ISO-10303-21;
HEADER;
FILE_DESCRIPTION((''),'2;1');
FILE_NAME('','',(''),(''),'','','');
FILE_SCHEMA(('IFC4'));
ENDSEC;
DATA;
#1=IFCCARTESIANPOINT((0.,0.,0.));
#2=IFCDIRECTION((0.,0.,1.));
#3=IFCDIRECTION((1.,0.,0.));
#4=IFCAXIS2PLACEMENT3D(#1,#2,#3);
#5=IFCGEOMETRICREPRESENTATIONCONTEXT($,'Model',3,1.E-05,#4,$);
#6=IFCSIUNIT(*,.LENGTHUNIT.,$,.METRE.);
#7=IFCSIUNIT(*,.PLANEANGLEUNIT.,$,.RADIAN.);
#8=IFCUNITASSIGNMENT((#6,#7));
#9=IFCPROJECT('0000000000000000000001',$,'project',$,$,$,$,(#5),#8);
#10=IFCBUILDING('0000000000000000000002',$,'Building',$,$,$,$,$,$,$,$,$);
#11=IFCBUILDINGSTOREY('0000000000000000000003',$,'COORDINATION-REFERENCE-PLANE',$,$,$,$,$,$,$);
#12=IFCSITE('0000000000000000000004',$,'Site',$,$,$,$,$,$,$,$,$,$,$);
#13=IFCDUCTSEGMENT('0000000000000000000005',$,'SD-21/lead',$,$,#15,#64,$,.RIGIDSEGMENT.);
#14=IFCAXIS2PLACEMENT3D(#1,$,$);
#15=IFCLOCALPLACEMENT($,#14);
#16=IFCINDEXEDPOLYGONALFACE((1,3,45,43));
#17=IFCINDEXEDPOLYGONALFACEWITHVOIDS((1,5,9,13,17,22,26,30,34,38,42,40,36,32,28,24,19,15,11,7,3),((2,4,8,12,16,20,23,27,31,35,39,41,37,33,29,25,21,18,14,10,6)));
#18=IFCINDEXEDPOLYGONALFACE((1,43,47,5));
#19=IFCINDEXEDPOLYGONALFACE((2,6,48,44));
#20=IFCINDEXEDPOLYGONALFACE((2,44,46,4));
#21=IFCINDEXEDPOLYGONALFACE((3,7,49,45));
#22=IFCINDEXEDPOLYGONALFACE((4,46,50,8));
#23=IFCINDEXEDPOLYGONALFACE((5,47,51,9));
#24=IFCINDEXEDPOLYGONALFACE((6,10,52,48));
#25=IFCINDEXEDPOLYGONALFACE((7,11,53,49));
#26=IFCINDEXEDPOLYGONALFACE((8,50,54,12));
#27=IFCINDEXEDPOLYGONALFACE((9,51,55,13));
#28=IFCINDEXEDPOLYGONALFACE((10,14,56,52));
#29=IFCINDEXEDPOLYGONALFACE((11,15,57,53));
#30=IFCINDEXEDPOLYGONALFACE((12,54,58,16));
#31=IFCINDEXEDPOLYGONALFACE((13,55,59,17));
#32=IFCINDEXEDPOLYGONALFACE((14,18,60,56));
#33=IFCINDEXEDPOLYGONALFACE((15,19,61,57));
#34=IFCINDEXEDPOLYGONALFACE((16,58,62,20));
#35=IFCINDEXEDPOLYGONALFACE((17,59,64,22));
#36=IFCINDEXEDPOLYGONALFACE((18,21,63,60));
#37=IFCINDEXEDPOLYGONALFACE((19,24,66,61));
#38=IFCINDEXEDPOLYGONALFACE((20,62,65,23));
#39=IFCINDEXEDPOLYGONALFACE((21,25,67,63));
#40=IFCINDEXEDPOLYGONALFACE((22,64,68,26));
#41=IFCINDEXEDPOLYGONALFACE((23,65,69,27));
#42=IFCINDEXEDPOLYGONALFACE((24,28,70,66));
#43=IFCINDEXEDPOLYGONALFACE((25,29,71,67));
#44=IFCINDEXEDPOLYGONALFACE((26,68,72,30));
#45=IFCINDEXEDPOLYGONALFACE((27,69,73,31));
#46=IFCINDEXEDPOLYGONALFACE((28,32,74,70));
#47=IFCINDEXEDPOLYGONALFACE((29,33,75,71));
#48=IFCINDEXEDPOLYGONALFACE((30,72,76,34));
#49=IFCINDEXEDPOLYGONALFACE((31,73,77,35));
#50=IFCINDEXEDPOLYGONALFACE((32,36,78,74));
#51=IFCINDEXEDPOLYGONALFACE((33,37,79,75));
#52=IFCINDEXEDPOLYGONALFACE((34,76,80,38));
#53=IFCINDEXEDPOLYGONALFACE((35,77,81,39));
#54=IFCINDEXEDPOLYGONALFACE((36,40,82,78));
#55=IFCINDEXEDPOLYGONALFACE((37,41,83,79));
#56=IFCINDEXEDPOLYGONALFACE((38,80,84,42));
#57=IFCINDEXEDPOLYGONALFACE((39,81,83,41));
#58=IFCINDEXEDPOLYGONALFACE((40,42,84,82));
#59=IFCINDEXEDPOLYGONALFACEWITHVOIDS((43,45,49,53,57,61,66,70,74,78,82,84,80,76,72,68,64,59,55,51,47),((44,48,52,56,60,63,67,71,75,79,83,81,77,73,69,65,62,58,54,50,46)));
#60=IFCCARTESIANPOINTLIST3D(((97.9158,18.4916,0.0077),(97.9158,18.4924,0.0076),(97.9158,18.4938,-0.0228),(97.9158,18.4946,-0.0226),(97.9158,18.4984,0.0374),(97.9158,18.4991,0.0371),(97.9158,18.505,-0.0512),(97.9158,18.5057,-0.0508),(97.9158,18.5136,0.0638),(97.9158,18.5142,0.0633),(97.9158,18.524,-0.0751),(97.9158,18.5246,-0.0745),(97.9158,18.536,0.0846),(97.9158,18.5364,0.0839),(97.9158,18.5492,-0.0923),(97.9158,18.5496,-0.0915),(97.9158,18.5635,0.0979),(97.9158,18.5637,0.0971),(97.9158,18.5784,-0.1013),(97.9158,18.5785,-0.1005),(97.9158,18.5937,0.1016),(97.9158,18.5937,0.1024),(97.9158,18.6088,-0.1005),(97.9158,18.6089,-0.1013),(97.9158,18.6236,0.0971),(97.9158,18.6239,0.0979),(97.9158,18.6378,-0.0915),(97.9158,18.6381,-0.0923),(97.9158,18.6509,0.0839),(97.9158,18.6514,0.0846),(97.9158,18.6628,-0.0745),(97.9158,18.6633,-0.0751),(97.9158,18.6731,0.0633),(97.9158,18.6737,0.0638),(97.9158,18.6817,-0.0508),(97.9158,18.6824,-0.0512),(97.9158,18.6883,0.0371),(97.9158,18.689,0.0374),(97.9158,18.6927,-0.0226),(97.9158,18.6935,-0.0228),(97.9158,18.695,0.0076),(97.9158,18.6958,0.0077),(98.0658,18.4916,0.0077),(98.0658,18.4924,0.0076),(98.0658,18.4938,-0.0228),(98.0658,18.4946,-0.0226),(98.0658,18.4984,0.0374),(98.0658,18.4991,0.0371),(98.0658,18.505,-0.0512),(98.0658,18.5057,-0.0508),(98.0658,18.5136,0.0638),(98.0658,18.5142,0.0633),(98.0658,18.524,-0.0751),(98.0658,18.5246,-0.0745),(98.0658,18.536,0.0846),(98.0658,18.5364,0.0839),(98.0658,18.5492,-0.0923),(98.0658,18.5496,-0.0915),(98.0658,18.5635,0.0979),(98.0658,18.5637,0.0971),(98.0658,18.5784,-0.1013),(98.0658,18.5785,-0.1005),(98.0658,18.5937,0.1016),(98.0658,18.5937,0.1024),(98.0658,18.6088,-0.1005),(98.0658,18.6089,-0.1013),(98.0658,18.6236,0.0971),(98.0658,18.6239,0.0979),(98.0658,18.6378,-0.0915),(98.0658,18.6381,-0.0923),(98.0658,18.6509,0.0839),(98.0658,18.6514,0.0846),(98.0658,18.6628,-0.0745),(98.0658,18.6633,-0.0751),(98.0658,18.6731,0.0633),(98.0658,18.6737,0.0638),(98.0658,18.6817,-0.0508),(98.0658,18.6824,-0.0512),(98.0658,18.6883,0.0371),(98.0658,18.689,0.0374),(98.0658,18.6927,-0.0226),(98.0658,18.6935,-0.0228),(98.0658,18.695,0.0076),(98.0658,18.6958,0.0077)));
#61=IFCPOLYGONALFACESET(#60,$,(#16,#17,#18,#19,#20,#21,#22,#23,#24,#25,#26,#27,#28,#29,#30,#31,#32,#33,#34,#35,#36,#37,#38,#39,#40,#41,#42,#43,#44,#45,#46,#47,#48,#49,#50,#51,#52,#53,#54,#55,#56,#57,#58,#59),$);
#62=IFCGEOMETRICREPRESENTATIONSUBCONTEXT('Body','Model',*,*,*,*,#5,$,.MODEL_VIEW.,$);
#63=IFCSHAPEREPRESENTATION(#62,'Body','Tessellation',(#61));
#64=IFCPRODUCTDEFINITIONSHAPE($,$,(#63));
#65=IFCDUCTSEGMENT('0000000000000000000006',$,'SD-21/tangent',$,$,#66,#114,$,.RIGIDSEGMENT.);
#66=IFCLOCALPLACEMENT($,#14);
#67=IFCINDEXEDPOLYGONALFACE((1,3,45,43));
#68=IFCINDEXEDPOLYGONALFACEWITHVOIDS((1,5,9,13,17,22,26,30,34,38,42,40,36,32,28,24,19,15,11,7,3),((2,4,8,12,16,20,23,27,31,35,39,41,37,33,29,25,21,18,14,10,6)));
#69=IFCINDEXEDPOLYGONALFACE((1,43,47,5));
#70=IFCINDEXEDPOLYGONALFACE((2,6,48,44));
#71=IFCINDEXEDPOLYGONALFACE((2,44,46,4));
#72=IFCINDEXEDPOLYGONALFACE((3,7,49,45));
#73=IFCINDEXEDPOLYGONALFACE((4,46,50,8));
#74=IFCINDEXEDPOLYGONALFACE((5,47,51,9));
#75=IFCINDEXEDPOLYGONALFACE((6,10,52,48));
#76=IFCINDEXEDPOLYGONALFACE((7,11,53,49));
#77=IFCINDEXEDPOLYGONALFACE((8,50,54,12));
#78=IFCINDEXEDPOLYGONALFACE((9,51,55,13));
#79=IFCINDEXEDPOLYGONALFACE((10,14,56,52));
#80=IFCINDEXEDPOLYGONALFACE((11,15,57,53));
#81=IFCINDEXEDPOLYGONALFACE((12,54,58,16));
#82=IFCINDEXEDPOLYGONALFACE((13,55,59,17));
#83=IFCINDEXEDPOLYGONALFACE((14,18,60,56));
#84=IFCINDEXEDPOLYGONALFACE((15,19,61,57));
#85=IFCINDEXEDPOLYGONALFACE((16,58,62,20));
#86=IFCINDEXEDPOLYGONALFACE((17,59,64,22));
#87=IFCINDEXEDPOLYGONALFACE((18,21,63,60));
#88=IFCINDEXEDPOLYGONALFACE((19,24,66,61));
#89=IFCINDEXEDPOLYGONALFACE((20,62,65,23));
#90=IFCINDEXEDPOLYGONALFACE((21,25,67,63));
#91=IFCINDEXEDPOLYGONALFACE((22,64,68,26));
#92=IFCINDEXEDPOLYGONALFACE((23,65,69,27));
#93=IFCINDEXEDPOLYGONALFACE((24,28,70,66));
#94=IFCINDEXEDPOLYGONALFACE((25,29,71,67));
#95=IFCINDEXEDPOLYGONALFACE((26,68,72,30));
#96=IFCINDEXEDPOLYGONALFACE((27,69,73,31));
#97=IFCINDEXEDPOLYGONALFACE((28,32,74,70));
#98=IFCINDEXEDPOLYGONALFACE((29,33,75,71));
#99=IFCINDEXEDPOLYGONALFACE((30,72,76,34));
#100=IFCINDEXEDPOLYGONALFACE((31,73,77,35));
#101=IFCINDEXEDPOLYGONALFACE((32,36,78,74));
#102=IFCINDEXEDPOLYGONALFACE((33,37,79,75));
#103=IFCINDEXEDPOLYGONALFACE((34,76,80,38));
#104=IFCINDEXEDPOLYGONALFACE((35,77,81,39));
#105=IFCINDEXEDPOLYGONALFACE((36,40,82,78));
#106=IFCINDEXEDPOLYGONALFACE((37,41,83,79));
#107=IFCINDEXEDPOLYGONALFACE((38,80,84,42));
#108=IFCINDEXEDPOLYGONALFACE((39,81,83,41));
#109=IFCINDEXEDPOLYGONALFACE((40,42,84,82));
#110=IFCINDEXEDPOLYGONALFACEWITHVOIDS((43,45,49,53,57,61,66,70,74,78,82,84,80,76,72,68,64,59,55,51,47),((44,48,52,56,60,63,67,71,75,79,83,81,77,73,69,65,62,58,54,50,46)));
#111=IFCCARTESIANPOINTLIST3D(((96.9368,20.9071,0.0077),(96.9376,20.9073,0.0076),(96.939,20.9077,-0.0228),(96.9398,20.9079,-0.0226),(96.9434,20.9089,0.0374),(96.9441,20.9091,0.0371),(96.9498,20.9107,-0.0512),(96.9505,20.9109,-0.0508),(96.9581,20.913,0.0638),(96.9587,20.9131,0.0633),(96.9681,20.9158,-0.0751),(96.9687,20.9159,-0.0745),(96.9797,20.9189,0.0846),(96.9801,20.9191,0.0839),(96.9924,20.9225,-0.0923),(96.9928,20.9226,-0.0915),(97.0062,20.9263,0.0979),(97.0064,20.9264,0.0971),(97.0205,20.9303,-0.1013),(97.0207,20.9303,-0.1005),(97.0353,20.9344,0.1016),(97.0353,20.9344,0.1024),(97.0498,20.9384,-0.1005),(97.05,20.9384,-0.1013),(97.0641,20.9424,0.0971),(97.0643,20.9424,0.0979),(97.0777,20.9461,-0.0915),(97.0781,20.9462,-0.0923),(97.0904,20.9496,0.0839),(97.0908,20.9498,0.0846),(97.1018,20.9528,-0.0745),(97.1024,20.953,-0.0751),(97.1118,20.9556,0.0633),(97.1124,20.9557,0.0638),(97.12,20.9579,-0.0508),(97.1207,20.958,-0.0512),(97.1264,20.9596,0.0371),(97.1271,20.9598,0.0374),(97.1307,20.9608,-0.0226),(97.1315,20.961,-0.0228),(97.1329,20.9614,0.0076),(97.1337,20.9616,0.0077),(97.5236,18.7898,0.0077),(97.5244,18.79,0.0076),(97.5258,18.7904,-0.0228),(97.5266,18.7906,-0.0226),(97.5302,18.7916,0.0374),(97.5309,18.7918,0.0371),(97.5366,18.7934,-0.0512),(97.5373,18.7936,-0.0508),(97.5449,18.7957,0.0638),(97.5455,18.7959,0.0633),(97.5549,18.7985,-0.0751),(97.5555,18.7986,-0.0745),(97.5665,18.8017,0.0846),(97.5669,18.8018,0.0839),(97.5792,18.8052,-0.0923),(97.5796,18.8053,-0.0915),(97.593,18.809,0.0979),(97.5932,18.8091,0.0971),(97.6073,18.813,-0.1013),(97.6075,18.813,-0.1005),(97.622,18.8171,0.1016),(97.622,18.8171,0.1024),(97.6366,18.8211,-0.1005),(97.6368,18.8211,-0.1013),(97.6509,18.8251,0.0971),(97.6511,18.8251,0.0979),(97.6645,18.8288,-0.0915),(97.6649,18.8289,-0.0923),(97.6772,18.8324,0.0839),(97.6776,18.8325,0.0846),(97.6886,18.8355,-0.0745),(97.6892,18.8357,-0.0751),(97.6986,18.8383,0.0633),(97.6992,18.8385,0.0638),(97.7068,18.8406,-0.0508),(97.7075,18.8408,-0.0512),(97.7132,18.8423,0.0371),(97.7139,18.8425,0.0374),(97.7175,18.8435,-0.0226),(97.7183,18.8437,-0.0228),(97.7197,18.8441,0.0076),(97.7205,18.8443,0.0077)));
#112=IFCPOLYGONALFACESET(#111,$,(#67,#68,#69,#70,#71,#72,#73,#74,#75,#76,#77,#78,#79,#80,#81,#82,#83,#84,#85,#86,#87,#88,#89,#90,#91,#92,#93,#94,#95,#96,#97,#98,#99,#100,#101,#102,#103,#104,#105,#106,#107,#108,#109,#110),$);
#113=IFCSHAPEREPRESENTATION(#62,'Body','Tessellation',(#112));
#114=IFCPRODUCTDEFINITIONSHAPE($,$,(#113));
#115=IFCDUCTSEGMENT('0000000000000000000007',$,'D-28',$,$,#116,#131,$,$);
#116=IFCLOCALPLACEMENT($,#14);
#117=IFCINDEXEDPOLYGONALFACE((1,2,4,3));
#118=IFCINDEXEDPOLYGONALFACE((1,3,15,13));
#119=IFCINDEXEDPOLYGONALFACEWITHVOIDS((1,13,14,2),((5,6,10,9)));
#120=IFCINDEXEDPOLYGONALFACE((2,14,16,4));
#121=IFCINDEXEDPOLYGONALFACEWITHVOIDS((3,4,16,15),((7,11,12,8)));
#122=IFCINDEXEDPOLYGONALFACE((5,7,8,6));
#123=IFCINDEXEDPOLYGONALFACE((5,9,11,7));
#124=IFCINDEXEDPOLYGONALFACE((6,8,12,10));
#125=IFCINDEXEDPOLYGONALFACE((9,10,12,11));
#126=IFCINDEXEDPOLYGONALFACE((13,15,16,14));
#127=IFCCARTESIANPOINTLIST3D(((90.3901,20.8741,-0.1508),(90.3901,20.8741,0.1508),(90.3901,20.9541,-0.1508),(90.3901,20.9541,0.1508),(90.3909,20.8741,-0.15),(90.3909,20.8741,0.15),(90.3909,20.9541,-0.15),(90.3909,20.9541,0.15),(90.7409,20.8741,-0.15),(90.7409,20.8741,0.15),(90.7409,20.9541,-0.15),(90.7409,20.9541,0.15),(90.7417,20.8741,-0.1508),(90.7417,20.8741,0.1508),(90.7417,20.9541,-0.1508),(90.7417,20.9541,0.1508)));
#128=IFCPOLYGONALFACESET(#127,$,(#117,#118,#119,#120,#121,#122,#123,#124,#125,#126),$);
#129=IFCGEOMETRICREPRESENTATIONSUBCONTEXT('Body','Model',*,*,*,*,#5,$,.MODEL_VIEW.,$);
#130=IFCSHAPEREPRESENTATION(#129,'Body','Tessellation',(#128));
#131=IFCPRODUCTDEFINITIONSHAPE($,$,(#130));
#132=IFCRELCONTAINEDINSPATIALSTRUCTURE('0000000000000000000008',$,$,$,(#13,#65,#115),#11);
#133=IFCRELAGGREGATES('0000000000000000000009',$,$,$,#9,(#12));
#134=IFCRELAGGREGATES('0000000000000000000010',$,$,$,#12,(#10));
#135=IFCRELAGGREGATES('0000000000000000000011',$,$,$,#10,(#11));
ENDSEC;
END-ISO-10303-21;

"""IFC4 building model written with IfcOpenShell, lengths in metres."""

from ifc_helpers import new_model, si_unit, frame, origin, origin_with_axes, place, context, subcontext, project, spatial, hollow_rectangle, hollow_circle, extrude, element, save


model = new_model("IFC4")

# Units and contexts
model_context_1 = context("Model", 3, precision=1e-05, world=origin_with_axes())
body_context_1 = subcontext(model_context_1, "Body", "Model", "MODEL_VIEW")
body_context_2 = subcontext(model_context_1, "Body", "Model", "MODEL_VIEW")
ifc_project = project(units=[si_unit("LENGTHUNIT", "METRE"), si_unit("PLANEANGLEUNIT", "RADIAN")], contexts=[model_context_1])

# Site, building, storey
site = spatial("IfcSite", under=ifc_project, Name="Site")
building = spatial("IfcBuilding", under=site, Name="Building")
storey = spatial("IfcBuildingStorey", under=building, Name="COORDINATION-REFERENCE-PLANE")

# Duct segment
duct_segment_1_placement = place(None, frame((98.0658, 18.5937, 0.0), z_axis=(-1.0, 0.0, 0.0), x_axis=(0.0, 0.0, 1.0)))
element("IfcDuctSegment", 1, at=duct_segment_1_placement, inside=storey, Name="SD-21/lead", PredefinedType="RIGIDSEGMENT", context=body_context_1, shape_type="SweptSolid", body=[
    extrude(hollow_circle(Radius=0.1024, WallThickness=0.0008), origin_with_axes(), (0.0, 0.0, 1.0), 0.15),
])

# Duct segment
duct_segment_2_placement = place(None, frame((97.622, 18.8171, 0.0), z_axis=(-0.267077, 0.963675, 0.0), x_axis=(0.0, 0.0, 1.0)))
element("IfcDuctSegment", 2, at=duct_segment_2_placement, inside=storey, Name="SD-21/tangent", PredefinedType="RIGIDSEGMENT", context=body_context_1, shape_type="SweptSolid", body=[
    extrude(hollow_circle(Radius=0.1024, WallThickness=0.0008), origin_with_axes(), (0.0, 0.0, 1.0), 2.1971),
])

# Duct segment
duct_segment_3_placement = place(None, frame((90.5659, 20.8741, 0.0), z_axis=(0.0, 1.0, 0.0), x_axis=(1.0, 0.0, 0.0)))
element("IfcDuctSegment", 3, at=duct_segment_3_placement, inside=storey, Name="D-28", context=body_context_2, shape_type="SweptSolid", body=[
    extrude(hollow_rectangle(XDim=0.3516, YDim=0.3016, WallThickness=0.0008), origin(), (0.0, 0.0, 1.0), 0.08),
])

save(model, "model.ifc")
